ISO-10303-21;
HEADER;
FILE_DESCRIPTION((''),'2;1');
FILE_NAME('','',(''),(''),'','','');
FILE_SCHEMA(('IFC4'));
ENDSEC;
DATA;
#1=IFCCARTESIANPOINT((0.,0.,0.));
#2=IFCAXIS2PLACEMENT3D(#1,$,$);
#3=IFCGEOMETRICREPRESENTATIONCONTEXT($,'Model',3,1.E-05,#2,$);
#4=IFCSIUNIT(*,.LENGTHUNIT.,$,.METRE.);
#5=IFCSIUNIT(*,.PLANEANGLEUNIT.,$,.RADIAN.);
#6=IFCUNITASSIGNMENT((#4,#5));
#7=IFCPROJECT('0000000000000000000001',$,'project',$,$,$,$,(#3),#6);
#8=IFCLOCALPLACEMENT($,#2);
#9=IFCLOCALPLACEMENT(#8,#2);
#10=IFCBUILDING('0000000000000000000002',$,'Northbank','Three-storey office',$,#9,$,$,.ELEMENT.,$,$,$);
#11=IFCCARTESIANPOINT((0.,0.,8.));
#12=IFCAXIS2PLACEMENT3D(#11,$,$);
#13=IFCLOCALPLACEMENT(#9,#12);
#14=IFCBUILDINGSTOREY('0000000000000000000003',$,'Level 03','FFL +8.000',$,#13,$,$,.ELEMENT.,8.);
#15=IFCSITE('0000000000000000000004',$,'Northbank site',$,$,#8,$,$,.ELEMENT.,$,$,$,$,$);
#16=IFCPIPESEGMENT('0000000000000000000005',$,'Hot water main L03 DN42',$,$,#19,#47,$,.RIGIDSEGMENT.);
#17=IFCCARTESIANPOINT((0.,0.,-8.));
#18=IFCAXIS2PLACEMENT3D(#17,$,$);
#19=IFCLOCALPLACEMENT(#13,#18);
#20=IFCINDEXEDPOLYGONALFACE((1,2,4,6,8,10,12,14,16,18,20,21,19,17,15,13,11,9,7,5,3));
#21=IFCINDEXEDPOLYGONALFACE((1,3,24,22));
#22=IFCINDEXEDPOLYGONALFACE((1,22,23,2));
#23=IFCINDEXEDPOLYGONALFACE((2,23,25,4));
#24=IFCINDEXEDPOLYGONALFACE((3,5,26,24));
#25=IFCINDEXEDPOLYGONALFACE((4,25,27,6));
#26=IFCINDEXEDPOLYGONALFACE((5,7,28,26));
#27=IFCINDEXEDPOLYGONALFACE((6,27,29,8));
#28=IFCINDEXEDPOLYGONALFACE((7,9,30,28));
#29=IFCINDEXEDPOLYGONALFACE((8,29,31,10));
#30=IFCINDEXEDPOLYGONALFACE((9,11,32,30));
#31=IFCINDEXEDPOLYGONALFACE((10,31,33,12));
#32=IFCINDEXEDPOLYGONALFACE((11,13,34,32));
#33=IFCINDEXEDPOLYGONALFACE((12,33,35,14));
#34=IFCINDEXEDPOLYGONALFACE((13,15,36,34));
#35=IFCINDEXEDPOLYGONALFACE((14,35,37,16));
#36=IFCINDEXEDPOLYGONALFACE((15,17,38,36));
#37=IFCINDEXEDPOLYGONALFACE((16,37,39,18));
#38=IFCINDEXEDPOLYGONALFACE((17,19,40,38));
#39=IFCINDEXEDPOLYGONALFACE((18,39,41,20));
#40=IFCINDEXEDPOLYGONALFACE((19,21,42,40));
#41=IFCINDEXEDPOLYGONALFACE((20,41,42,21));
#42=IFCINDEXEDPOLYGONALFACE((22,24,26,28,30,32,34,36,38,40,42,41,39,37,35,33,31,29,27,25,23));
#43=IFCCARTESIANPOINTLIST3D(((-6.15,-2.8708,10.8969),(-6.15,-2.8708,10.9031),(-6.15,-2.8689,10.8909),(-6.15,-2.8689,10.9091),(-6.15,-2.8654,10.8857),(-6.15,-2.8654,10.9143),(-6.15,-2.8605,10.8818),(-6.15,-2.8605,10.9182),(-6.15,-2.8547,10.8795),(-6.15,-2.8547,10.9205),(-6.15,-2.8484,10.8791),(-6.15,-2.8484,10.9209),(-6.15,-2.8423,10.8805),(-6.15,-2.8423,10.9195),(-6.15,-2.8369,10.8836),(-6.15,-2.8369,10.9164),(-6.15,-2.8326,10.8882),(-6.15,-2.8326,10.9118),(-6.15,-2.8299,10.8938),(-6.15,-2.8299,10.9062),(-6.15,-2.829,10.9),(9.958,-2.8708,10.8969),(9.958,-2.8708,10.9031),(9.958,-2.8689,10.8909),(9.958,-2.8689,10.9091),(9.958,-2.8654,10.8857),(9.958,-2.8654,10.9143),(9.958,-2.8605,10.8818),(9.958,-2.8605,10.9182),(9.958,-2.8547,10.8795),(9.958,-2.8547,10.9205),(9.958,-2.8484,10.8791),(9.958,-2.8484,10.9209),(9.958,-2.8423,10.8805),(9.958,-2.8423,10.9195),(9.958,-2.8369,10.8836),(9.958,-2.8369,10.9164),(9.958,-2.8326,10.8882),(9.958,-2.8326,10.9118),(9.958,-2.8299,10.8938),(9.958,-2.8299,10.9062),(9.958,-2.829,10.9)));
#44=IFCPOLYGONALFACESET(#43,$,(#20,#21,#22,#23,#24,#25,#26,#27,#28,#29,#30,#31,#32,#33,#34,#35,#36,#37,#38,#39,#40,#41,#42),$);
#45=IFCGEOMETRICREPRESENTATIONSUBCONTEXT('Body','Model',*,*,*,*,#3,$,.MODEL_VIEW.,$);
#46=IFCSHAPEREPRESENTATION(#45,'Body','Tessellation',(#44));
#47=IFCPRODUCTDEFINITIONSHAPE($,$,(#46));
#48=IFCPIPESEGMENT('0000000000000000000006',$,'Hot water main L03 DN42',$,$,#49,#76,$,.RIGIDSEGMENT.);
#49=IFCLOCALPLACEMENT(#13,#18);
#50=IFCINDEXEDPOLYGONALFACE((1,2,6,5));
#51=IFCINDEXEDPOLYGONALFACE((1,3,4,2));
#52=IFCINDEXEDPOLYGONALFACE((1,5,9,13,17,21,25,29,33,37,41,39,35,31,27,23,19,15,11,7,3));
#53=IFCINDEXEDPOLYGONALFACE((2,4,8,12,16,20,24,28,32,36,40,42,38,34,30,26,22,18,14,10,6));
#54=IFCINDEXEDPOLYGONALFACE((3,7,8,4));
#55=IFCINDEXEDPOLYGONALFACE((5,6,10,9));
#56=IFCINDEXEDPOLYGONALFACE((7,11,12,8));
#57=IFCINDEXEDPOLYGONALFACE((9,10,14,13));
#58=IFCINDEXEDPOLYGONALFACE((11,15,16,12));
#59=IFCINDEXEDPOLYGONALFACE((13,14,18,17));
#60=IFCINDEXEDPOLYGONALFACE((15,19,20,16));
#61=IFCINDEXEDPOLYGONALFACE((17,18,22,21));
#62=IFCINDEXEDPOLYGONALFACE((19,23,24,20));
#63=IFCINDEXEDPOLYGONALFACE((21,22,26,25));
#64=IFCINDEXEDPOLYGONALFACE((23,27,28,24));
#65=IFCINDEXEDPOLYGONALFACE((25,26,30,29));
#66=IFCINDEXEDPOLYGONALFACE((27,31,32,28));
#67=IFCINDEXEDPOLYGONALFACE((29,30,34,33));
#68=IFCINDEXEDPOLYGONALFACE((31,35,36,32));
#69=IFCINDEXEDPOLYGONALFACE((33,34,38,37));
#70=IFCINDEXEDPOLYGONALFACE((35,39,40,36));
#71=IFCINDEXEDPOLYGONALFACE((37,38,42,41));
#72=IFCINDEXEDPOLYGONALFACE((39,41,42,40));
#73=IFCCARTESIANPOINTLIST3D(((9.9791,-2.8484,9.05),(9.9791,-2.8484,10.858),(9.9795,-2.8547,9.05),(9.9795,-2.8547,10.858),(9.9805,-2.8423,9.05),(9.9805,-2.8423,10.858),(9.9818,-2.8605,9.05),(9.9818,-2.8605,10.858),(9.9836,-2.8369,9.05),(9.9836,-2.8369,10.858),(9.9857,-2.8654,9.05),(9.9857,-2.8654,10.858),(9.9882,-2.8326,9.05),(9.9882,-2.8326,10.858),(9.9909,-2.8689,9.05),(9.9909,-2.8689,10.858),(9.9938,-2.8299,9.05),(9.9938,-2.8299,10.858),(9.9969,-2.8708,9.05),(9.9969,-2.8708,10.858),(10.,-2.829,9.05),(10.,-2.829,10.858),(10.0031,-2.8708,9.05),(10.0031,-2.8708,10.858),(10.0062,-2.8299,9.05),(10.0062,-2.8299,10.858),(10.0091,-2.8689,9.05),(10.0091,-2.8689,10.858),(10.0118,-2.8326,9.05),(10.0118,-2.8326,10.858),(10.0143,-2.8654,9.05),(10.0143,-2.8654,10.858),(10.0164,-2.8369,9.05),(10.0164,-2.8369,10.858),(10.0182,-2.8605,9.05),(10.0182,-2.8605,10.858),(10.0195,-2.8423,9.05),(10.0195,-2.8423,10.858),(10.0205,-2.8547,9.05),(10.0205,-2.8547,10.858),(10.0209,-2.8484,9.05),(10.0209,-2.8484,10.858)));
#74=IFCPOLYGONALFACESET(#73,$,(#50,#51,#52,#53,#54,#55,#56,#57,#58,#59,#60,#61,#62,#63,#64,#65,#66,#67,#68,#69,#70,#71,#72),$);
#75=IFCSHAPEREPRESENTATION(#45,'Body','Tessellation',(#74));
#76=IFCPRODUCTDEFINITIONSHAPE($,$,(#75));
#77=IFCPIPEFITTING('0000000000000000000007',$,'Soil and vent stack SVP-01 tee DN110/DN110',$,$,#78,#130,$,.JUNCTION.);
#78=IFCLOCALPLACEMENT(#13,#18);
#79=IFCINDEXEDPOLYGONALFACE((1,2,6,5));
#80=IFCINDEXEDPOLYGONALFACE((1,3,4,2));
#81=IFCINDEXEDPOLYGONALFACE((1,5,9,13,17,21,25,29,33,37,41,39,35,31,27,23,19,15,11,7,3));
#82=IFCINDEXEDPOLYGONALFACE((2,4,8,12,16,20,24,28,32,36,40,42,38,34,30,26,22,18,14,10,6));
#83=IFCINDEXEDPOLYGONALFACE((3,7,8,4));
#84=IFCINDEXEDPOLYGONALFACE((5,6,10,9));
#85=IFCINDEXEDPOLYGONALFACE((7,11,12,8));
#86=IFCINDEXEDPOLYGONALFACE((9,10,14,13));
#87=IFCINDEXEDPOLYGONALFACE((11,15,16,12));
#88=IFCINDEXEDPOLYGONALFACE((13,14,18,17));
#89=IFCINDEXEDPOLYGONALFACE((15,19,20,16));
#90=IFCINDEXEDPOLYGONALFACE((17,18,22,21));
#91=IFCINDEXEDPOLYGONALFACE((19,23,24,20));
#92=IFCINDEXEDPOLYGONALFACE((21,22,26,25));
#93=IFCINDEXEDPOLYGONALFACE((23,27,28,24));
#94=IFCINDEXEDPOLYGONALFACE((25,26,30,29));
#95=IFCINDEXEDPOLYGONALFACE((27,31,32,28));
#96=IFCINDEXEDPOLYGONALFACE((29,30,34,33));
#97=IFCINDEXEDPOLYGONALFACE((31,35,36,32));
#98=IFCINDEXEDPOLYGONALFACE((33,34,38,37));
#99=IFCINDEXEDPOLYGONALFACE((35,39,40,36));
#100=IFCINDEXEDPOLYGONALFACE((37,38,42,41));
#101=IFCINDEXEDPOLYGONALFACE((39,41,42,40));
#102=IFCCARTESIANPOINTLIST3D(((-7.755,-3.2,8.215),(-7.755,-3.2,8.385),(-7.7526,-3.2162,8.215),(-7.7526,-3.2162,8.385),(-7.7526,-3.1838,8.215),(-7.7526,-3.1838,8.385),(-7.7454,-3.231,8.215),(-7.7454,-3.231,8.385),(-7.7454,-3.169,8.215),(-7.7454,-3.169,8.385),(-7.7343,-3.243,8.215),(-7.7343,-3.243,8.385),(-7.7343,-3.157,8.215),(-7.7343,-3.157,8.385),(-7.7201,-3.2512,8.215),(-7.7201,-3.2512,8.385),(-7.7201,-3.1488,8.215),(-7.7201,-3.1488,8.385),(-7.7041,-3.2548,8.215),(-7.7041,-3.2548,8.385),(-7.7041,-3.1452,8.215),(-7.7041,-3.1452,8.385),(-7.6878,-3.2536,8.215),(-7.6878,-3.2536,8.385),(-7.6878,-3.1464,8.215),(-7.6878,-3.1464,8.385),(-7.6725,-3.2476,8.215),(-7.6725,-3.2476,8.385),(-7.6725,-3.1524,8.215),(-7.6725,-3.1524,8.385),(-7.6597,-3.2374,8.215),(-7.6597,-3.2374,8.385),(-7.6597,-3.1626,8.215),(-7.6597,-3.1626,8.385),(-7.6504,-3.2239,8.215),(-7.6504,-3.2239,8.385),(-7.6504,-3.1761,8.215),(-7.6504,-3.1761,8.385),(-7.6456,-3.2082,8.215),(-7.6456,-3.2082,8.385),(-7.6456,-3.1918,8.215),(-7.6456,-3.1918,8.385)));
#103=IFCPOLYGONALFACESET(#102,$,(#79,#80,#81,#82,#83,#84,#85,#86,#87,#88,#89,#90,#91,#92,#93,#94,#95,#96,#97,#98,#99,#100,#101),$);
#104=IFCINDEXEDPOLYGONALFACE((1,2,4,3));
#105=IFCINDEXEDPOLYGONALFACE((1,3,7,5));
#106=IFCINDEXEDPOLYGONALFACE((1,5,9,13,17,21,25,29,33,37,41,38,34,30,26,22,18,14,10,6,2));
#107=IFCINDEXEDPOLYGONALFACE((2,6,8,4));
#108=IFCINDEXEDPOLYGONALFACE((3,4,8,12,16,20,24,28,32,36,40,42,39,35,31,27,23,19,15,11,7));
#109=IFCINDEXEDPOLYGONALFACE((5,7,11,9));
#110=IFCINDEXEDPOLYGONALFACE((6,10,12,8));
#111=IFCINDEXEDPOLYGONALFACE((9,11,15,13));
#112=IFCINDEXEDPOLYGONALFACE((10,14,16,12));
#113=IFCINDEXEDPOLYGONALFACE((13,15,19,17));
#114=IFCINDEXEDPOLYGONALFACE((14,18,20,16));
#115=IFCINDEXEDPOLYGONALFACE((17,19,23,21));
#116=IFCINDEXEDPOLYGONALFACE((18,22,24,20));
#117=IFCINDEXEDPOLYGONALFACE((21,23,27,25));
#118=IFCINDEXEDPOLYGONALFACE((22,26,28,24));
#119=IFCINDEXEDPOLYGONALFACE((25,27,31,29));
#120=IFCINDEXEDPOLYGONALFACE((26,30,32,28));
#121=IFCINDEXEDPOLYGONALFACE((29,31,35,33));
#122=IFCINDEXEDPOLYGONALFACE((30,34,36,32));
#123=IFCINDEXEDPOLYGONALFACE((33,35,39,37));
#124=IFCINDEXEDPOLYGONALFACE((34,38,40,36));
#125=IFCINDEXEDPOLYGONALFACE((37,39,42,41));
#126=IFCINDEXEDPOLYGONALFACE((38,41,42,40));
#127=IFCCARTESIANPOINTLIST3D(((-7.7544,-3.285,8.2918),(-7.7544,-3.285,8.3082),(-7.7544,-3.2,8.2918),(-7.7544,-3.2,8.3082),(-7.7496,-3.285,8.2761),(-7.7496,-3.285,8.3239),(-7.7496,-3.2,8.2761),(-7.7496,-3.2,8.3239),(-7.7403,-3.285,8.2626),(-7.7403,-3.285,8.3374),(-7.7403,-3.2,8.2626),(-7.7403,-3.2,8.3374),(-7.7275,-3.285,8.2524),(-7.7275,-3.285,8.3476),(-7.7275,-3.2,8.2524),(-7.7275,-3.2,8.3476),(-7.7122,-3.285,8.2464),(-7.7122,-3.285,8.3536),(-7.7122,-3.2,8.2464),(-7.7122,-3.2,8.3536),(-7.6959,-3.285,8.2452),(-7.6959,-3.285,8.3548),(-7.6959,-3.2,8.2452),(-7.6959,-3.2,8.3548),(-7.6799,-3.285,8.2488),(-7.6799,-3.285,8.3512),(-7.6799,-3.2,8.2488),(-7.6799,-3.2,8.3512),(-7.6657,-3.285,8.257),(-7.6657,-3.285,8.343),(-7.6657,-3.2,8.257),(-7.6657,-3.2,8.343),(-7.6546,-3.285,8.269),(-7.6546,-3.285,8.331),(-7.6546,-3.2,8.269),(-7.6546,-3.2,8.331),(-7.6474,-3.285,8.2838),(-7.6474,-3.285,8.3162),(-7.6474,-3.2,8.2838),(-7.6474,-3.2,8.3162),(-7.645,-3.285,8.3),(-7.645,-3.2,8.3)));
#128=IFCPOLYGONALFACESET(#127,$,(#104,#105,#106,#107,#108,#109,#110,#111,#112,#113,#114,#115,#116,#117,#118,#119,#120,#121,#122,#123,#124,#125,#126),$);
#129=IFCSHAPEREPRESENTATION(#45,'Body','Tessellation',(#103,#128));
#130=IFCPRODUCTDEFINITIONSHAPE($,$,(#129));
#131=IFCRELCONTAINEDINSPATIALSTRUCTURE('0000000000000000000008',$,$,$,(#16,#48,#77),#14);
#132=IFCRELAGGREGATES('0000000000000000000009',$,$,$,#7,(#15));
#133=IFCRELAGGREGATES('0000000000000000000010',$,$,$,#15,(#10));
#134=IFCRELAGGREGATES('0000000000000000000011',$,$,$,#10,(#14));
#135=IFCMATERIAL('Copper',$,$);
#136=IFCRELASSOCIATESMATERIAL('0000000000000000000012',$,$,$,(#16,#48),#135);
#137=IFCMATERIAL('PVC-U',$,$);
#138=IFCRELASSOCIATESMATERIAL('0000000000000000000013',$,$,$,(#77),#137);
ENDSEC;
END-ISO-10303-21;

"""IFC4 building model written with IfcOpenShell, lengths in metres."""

from ifc_helpers import new_model, si_unit, frame, origin, place, context, subcontext, project, spatial, circle, extrude, material, element, save


model = new_model("IFC4")

# Units and contexts
model_context = context("Model", 3, precision=1e-05, world=origin())
body_context = subcontext(model_context, "Body", "Model", "MODEL_VIEW")
ifc_project = project(units=[si_unit("LENGTHUNIT", "METRE"), si_unit("PLANEANGLEUNIT", "RADIAN")], contexts=[model_context])

# Site, building, storey
site_placement = place(None, origin())
site = spatial("IfcSite", under=ifc_project, at=site_placement, Name="Northbank site", CompositionType="ELEMENT")
building_placement = place(site_placement, origin())
building = spatial("IfcBuilding", under=site, at=building_placement, Name="Northbank", Description="Three-storey office", CompositionType="ELEMENT")
storey_placement = place(building_placement, frame((0.0, 0.0, 8.0)))
storey = spatial("IfcBuildingStorey", under=building, at=storey_placement, Name="Level 03", Description="FFL +8.000", CompositionType="ELEMENT", Elevation=8.0)

# Shared definitions
ifc_material_1 = material(Name="Copper")

# Pipe segments
pipe_segment_1_placement = place(storey_placement, frame((0.0, 0.0, -8.0)))
element("IfcPipeSegment", 1, at=pipe_segment_1_placement, inside=storey, material=ifc_material_1, Name="Hot water main L03 DN42", PredefinedType="RIGIDSEGMENT", context=body_context, shape_type="SweptSolid", body=[
    extrude(circle(Radius=0.021), frame((-6.15, -2.85, 10.9), z_axis=(1.0, 0.0, 0.0), x_axis=(0.0, 1.0, 0.0)), (0.0, 0.0, 1.0), 16.108),
])
pipe_segment_2_placement = place(storey_placement, frame((0.0, 0.0, -8.0)))
element("IfcPipeSegment", 2, at=pipe_segment_2_placement, inside=storey, material=ifc_material_1, Name="Hot water main L03 DN42", PredefinedType="RIGIDSEGMENT", context=body_context, shape_type="SweptSolid", body=[
    extrude(circle(Radius=0.021), frame((10.0, -2.85, 10.858), z_axis=(0.0, 0.0, -1.0), x_axis=(0.0, 1.0, 0.0)), (0.0, 0.0, 1.0), 1.808),
])

# Pipe fitting
ifc_material_2 = material(Name="PVC-U")
pipe_fitting_1_placement = place(storey_placement, frame((0.0, 0.0, -8.0)))
element("IfcPipeFitting", 3, at=pipe_fitting_1_placement, inside=storey, material=ifc_material_2, Name="Soil and vent stack SVP-01 tee DN110/DN110", PredefinedType="JUNCTION", context=body_context, shape_type="SweptSolid", body=[
    extrude(circle(Radius=0.055), frame((-7.7, -3.2, 8.215), z_axis=(0.0, 0.0, 1.0), x_axis=(-1.0, 0.0, 0.0)), (0.0, 0.0, 1.0), 0.17),
    extrude(circle(Radius=0.055), frame((-7.7, -3.2, 8.3), z_axis=(0.0, -1.0, 0.0), x_axis=(1.0, 0.0, 0.0)), (0.0, 0.0, 1.0), 0.085),
])

save(model, "model.ifc")
